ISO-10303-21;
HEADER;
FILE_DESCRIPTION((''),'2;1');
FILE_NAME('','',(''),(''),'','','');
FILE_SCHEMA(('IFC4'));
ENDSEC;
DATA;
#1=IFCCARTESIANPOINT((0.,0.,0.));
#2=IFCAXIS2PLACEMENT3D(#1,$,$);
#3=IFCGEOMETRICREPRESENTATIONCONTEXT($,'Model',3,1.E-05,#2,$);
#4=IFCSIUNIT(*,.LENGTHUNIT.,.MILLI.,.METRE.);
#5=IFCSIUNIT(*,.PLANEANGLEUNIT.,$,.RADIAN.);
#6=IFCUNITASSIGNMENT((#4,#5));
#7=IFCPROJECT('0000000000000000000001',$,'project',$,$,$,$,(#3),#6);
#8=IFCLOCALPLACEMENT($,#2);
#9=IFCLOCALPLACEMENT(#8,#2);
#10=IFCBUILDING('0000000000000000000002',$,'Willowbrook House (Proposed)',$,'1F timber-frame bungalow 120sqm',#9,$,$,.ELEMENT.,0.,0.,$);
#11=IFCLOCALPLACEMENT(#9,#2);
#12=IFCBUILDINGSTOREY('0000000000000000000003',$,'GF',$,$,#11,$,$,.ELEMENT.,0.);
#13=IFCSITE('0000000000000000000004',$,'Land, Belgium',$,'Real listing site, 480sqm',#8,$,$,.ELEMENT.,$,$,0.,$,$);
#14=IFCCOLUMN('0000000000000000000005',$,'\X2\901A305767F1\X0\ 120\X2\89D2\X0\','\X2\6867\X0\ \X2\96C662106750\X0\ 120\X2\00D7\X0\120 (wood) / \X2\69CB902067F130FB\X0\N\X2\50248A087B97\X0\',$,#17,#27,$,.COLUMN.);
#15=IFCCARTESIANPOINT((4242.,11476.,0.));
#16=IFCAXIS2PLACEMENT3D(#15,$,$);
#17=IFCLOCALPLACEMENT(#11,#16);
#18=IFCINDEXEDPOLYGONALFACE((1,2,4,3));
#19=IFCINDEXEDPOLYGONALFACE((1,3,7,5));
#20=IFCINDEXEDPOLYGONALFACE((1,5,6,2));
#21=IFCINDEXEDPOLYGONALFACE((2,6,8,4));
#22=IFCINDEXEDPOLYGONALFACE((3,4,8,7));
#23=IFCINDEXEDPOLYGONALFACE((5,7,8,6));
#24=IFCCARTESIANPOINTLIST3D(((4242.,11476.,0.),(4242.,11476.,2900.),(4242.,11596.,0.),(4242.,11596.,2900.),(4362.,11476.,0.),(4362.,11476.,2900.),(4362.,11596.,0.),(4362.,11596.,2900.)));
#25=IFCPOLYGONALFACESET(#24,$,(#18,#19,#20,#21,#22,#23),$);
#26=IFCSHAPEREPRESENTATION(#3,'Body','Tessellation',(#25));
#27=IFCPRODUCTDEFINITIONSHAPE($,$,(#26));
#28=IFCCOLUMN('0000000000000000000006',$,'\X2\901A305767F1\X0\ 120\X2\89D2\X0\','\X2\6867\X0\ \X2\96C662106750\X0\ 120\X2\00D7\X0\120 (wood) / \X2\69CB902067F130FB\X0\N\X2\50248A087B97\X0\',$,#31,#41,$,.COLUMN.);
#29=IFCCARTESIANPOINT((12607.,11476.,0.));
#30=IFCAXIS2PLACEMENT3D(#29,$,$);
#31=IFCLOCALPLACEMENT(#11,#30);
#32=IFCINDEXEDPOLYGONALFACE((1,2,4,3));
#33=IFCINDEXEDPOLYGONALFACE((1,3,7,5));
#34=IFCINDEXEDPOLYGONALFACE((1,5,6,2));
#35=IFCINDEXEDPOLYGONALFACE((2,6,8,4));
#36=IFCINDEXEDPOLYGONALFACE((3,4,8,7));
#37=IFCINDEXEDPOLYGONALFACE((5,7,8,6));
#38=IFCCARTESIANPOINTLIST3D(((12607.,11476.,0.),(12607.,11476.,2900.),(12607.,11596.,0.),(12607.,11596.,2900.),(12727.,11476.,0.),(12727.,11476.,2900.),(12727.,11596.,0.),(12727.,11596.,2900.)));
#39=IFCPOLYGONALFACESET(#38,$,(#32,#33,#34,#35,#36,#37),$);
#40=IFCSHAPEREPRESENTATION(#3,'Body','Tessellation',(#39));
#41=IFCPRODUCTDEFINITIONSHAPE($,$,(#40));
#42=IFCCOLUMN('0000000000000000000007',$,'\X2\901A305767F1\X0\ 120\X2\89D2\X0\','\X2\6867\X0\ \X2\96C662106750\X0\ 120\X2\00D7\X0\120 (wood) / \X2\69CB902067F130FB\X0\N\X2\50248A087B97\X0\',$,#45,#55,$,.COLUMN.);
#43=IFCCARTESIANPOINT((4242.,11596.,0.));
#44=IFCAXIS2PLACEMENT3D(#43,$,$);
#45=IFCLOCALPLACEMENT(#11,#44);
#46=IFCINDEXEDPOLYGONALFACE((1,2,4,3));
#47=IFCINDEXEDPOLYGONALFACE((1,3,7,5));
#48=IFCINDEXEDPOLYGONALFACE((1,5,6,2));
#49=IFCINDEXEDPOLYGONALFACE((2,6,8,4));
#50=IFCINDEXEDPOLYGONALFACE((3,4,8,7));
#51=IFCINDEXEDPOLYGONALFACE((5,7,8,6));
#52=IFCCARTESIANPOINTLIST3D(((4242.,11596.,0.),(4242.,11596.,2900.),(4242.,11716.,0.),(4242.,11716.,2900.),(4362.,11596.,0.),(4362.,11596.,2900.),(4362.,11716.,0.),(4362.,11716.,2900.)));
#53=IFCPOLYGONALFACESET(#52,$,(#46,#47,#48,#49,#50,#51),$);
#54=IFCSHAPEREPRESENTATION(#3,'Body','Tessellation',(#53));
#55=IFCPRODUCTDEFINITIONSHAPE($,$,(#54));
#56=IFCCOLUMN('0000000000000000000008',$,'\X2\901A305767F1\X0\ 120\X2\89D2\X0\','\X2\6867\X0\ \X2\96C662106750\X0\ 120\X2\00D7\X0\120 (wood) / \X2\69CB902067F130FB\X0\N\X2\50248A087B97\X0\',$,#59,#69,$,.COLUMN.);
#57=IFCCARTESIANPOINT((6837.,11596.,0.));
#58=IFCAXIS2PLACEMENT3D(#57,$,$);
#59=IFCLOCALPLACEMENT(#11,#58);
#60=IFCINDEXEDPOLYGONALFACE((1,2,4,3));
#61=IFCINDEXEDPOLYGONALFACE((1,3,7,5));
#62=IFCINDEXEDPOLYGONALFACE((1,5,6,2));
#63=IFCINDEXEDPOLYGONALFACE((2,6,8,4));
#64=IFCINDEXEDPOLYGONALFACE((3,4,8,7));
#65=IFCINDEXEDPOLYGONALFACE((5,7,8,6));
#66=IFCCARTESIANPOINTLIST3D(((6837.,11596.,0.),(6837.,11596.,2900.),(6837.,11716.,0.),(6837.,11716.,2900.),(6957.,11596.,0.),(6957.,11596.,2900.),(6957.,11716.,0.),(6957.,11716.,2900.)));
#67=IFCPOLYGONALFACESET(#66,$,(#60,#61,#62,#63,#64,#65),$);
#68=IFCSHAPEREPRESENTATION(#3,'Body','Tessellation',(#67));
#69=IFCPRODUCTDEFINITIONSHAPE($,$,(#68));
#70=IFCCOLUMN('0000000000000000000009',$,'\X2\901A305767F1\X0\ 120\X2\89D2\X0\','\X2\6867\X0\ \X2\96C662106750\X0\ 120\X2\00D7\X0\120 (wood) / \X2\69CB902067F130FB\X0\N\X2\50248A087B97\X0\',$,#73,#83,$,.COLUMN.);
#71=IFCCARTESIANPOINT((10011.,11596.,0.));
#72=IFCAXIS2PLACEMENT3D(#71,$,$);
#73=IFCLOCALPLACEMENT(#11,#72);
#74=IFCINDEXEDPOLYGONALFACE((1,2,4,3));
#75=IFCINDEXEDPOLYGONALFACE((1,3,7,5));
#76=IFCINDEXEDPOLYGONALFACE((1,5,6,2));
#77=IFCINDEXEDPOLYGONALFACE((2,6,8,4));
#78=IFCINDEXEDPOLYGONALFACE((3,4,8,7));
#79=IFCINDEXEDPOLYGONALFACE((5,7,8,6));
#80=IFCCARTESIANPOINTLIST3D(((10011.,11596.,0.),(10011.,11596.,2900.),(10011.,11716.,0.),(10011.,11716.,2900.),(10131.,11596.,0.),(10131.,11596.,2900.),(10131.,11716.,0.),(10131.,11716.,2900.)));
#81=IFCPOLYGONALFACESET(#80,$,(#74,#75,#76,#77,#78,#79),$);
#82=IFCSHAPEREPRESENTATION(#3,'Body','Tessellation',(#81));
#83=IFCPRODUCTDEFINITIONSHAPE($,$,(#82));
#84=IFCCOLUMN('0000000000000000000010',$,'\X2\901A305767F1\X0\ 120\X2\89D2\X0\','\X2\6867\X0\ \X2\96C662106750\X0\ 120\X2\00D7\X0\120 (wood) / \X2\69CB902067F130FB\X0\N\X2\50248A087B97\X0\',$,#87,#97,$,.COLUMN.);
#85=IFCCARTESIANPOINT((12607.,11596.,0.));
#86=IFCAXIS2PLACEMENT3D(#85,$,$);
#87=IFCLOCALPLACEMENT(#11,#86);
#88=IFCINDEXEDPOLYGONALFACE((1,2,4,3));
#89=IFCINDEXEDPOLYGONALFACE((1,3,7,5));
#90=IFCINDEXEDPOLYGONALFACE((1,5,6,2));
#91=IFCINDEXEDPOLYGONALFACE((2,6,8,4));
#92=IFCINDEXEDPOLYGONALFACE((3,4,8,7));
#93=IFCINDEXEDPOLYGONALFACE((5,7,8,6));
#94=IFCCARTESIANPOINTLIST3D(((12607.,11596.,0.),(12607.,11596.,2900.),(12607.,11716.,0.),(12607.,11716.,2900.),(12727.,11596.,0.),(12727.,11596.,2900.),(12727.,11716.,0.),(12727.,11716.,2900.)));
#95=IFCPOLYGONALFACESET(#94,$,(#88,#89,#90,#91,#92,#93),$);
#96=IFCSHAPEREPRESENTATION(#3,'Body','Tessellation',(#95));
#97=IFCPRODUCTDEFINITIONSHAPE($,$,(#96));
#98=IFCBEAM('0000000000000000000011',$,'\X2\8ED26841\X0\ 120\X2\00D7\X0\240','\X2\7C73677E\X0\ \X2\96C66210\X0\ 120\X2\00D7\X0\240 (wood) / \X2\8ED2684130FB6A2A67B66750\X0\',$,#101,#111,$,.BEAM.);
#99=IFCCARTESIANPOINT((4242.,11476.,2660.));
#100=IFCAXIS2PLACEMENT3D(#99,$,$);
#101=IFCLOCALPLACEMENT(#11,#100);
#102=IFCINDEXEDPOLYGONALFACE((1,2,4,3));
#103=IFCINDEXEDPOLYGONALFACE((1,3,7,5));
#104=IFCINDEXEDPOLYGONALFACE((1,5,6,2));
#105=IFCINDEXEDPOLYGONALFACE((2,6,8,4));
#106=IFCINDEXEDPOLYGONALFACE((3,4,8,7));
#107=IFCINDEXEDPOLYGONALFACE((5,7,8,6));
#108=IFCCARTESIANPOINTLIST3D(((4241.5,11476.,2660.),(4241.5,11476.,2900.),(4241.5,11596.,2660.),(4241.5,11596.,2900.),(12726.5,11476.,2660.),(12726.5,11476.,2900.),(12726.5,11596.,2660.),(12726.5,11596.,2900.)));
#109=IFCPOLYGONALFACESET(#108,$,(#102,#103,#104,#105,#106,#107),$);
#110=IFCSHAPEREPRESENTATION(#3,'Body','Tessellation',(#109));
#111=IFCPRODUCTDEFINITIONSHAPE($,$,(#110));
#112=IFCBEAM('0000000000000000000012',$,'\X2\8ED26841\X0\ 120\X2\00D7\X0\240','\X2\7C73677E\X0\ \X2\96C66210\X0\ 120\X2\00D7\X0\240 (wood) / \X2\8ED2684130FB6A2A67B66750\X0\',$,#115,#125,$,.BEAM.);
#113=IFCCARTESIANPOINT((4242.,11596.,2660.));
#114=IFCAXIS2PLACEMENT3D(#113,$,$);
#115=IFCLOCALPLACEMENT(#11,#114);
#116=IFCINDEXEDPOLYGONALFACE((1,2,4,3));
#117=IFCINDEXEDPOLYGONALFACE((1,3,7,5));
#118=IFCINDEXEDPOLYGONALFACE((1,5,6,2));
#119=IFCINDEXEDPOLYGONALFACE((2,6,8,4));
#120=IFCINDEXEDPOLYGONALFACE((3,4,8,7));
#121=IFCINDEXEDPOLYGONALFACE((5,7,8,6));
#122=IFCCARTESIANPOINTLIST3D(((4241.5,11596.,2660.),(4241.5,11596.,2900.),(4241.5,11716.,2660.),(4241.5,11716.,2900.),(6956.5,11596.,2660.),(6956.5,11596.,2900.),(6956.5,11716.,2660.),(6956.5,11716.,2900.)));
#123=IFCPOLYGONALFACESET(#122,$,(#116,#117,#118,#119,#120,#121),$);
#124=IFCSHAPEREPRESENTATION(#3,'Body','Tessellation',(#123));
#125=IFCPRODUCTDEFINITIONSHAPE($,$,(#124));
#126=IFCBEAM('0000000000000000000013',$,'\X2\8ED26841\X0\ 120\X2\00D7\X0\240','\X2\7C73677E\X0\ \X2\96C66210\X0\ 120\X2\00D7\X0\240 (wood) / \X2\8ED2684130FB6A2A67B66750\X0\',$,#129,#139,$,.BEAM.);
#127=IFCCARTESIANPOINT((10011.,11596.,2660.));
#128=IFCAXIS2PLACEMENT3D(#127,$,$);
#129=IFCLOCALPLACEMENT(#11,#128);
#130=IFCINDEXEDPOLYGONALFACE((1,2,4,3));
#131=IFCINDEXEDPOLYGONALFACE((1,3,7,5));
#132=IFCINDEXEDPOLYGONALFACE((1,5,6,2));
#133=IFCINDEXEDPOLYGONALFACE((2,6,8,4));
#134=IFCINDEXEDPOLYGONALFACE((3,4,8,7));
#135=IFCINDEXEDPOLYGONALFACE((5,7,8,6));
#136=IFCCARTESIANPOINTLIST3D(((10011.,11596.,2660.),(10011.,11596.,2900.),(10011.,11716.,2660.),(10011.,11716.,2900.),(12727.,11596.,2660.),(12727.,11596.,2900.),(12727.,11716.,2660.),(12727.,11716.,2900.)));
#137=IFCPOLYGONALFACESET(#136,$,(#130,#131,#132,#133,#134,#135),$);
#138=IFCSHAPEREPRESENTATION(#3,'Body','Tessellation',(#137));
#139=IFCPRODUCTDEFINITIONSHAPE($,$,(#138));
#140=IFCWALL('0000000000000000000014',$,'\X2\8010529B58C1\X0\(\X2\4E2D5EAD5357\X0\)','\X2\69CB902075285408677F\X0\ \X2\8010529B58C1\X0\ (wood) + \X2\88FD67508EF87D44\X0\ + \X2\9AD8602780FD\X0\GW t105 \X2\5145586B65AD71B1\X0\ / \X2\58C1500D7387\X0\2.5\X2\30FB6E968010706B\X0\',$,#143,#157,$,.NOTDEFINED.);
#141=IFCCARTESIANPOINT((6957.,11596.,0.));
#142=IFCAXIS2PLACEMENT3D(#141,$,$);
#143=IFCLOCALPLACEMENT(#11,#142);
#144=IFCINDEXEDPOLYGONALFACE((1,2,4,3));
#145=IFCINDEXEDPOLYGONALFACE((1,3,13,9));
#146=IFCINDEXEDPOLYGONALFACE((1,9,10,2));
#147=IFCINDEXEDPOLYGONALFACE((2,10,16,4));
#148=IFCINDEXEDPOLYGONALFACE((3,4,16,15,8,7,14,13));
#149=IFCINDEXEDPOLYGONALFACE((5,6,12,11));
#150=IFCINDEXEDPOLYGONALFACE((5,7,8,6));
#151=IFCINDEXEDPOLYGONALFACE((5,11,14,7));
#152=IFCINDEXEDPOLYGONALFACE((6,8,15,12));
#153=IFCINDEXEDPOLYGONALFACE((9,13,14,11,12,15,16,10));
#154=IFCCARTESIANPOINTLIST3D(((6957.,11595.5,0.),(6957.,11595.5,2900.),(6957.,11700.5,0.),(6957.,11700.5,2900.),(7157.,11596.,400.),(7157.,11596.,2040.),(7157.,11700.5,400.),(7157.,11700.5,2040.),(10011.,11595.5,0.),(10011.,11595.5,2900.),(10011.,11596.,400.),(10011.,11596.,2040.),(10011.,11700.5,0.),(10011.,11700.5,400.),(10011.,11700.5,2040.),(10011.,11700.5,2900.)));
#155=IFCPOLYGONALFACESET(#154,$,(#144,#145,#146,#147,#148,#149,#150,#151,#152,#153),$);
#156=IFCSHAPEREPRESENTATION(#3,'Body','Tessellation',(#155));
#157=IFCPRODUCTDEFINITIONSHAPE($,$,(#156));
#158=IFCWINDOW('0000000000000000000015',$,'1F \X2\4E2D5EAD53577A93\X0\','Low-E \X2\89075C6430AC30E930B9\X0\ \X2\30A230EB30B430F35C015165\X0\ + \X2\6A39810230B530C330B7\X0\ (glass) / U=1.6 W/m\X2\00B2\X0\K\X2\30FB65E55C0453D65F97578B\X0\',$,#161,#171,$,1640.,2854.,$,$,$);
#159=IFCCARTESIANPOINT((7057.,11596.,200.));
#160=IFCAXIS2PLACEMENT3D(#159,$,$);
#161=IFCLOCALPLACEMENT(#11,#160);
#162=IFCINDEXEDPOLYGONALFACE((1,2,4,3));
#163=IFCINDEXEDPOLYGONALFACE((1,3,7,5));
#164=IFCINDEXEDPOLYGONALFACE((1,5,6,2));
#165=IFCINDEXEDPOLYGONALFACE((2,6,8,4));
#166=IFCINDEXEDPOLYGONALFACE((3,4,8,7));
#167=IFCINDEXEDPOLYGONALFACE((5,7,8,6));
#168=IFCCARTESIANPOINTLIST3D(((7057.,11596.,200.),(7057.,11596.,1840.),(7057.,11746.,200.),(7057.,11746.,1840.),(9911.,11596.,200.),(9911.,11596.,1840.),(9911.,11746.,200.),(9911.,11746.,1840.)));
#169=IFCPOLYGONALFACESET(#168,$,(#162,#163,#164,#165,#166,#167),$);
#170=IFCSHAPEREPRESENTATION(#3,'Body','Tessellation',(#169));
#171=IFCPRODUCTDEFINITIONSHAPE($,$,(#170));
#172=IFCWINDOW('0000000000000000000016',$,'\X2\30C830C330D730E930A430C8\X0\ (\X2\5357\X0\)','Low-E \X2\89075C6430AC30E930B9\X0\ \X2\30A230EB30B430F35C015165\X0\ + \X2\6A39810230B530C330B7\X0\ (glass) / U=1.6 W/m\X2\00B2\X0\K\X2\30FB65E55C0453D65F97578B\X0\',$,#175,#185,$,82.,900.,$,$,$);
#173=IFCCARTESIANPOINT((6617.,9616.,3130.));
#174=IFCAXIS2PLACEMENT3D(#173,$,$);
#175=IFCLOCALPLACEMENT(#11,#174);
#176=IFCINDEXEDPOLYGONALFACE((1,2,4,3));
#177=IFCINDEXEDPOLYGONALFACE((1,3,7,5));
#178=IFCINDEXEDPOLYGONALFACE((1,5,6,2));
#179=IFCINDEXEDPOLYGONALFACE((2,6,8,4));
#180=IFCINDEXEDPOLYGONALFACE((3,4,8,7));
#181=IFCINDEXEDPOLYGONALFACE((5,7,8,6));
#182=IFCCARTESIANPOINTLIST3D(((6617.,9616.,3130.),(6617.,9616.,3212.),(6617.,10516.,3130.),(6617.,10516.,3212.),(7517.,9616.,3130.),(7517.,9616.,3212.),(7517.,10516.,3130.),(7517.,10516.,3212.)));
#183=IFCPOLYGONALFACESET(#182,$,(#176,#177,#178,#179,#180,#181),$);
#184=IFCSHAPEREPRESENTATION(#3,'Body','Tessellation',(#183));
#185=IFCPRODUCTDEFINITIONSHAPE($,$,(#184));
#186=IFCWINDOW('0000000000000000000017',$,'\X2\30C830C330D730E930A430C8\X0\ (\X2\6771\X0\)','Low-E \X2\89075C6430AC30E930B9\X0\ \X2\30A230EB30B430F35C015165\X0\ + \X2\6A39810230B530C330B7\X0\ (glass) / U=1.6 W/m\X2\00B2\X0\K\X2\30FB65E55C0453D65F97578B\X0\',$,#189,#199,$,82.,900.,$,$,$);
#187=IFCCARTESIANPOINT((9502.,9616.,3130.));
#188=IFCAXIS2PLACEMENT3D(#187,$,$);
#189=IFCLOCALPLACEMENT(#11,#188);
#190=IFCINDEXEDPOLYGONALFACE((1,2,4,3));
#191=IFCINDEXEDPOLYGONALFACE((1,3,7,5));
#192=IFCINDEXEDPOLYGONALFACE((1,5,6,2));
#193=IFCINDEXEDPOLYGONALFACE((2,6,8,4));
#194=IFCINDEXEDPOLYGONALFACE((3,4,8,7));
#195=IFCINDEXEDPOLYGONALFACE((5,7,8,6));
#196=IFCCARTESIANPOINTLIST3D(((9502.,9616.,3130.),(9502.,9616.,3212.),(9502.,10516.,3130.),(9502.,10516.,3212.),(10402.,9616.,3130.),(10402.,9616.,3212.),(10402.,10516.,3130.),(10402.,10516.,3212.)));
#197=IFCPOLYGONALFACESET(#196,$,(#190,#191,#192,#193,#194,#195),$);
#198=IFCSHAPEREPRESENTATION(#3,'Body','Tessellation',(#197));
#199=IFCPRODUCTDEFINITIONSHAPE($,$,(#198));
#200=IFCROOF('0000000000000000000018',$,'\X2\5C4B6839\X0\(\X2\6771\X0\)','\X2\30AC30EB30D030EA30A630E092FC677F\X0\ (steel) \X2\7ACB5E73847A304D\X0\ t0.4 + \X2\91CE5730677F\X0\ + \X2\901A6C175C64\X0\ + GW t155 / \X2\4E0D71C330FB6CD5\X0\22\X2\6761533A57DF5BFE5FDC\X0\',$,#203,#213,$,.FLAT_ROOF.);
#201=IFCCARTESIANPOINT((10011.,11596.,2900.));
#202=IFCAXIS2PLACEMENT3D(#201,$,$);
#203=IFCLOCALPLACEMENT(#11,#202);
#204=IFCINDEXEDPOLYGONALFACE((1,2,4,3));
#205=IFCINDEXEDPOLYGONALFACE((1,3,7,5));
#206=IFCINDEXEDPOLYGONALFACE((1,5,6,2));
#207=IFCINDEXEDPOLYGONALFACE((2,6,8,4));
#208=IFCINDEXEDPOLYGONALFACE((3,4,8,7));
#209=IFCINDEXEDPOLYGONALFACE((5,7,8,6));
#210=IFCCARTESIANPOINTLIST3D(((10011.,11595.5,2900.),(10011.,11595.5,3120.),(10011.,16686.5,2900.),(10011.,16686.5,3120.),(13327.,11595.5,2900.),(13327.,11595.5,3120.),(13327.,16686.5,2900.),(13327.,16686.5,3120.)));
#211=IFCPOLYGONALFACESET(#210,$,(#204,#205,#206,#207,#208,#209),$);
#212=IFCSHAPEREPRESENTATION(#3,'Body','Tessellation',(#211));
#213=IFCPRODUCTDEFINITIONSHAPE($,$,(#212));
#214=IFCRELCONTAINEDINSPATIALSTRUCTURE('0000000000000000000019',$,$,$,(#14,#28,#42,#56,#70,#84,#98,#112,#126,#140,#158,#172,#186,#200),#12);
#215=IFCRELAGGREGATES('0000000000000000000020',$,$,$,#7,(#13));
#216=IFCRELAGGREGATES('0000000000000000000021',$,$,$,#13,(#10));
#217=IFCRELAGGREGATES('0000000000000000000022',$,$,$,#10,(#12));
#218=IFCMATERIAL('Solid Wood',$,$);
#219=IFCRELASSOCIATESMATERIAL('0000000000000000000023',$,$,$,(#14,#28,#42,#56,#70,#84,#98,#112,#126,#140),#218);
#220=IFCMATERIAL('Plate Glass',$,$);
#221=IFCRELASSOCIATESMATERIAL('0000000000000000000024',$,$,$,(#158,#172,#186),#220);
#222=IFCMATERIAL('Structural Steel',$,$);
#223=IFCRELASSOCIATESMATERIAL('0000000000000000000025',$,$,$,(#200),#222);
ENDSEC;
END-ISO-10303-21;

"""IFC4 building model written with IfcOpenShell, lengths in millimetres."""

from ifc_helpers import new_model, si_unit, frame, frame_2d, origin, place, context, project, spatial, rectangle, extrude, material, element, fill, save


model = new_model("IFC4")

# Units and contexts
model_context = context("Model", 3, precision=1e-05, world=origin())
ifc_project = project(units=[si_unit("LENGTHUNIT", "METRE", prefix="MILLI"), si_unit("PLANEANGLEUNIT", "RADIAN")], contexts=[model_context])

# Site, building, storey
site_placement = place(None, origin())
site = spatial("IfcSite", under=ifc_project, at=site_placement, Name="Land, Belgium", ObjectType="Real listing site, 480sqm", CompositionType="ELEMENT", RefElevation=0.0)
building_placement = place(site_placement, origin())
building = spatial("IfcBuilding", under=site, at=building_placement, Name="Willowbrook House (Proposed)", ObjectType="1F timber-frame bungalow 120sqm", CompositionType="ELEMENT", ElevationOfRefHeight=0.0, ElevationOfTerrain=0.0)
storey_placement = place(building_placement, origin())
storey = spatial("IfcBuildingStorey", under=building, at=storey_placement, Name="GF", CompositionType="ELEMENT", Elevation=0.0)

# Columns
ifc_material_1 = material(Name="Solid Wood")
column_1_placement = place(storey_placement, frame((4242.0, 11476.0, 0.0)))
element("IfcColumn", 1, at=column_1_placement, inside=storey, material=ifc_material_1, Name="通し柱 120角", Description="桧 集成材 120×120 (wood) / 構造柱・N値計算", PredefinedType="COLUMN", context=model_context, shape_type="SweptSolid", body=[
    extrude(rectangle(XDim=120.0, YDim=120.0, at=frame_2d((60.0, 60.0))), frame((4242.0, 11476.0, 0.0)), (0.0, 0.0, 1.0), 2900.0),
])
column_2_placement = place(storey_placement, frame((12607.0, 11476.0, 0.0)))
element("IfcColumn", 2, at=column_2_placement, inside=storey, material=ifc_material_1, Name="通し柱 120角", Description="桧 集成材 120×120 (wood) / 構造柱・N値計算", PredefinedType="COLUMN", context=model_context, shape_type="SweptSolid", body=[
    extrude(rectangle(XDim=120.0, YDim=120.0, at=frame_2d((60.0, 60.0))), frame((12607.0, 11476.0, 0.0)), (0.0, 0.0, 1.0), 2900.0),
])
column_3_placement = place(storey_placement, frame((4242.0, 11596.0, 0.0)))
element("IfcColumn", 3, at=column_3_placement, inside=storey, material=ifc_material_1, Name="通し柱 120角", Description="桧 集成材 120×120 (wood) / 構造柱・N値計算", PredefinedType="COLUMN", context=model_context, shape_type="SweptSolid", body=[
    extrude(rectangle(XDim=120.0, YDim=120.0, at=frame_2d((60.0, 60.0))), frame((4242.0, 11596.0, 0.0)), (0.0, 0.0, 1.0), 2900.0),
])
column_4_placement = place(storey_placement, frame((6837.0, 11596.0, 0.0)))
element("IfcColumn", 4, at=column_4_placement, inside=storey, material=ifc_material_1, Name="通し柱 120角", Description="桧 集成材 120×120 (wood) / 構造柱・N値計算", PredefinedType="COLUMN", context=model_context, shape_type="SweptSolid", body=[
    extrude(rectangle(XDim=120.0, YDim=120.0, at=frame_2d((60.0, 60.0))), frame((6837.0, 11596.0, 0.0)), (0.0, 0.0, 1.0), 2900.0),
])
column_5_placement = place(storey_placement, frame((10011.0, 11596.0, 0.0)))
element("IfcColumn", 5, at=column_5_placement, inside=storey, material=ifc_material_1, Name="通し柱 120角", Description="桧 集成材 120×120 (wood) / 構造柱・N値計算", PredefinedType="COLUMN", context=model_context, shape_type="SweptSolid", body=[
    extrude(rectangle(XDim=120.0, YDim=120.0, at=frame_2d((60.0, 60.0))), frame((10011.0, 11596.0, 0.0)), (0.0, 0.0, 1.0), 2900.0),
])
column_6_placement = place(storey_placement, frame((12607.0, 11596.0, 0.0)))
element("IfcColumn", 6, at=column_6_placement, inside=storey, material=ifc_material_1, Name="通し柱 120角", Description="桧 集成材 120×120 (wood) / 構造柱・N値計算", PredefinedType="COLUMN", context=model_context, shape_type="SweptSolid", body=[
    extrude(rectangle(XDim=120.0, YDim=120.0, at=frame_2d((60.0, 60.0))), frame((12607.0, 11596.0, 0.0)), (0.0, 0.0, 1.0), 2900.0),
])

# Beams
beam_1_placement = place(storey_placement, frame((4242.0, 11476.0, 2660.0)))
element("IfcBeam", 7, at=beam_1_placement, inside=storey, material=ifc_material_1, Name="軒桁 120×240", Description="米松 集成 120×240 (wood) / 軒桁・横架材", PredefinedType="BEAM", context=model_context, shape_type="SweptSolid", body=[
    extrude(rectangle(XDim=8485.0, YDim=120.0, at=frame_2d((4242.0, 60.0))), frame((4242.0, 11476.0, 2660.0)), (0.0, 0.0, 1.0), 240.0),
])
beam_2_placement = place(storey_placement, frame((4242.0, 11596.0, 2660.0)))
element("IfcBeam", 8, at=beam_2_placement, inside=storey, material=ifc_material_1, Name="軒桁 120×240", Description="米松 集成 120×240 (wood) / 軒桁・横架材", PredefinedType="BEAM", context=model_context, shape_type="SweptSolid", body=[
    extrude(rectangle(XDim=2715.0, YDim=120.0, at=frame_2d((1357.0, 60.0))), frame((4242.0, 11596.0, 2660.0)), (0.0, 0.0, 1.0), 240.0),
])
beam_3_placement = place(storey_placement, frame((10011.0, 11596.0, 2660.0)))
element("IfcBeam", 9, at=beam_3_placement, inside=storey, material=ifc_material_1, Name="軒桁 120×240", Description="米松 集成 120×240 (wood) / 軒桁・横架材", PredefinedType="BEAM", context=model_context, shape_type="SweptSolid", body=[
    extrude(rectangle(XDim=2716.0, YDim=120.0, at=frame_2d((1358.0, 60.0))), frame((10011.0, 11596.0, 2660.0)), (0.0, 0.0, 1.0), 240.0),
])

# Wall, opening, window
wall_1_placement = place(storey_placement, frame((6957.0, 11596.0, 0.0)))
wall_1 = element("IfcWall", 10, at=wall_1_placement, inside=storey, material=ifc_material_1, Name="耐力壁(中庭南)", Description="構造用合板 耐力壁 (wood) + 製材軸組 + 高性能GW t105 充填断熱 / 壁倍率2.5・準耐火", PredefinedType="NOTDEFINED", context=model_context, shape_type="SweptSolid", body=[
    extrude(rectangle(XDim=3054.0, YDim=105.0, at=frame_2d((1527.0, 52.0))), frame((6957.0, 11596.0, 0.0)), (0.0, 0.0, 1.0), 2900.0),
])
opening_placement = place(storey_placement, frame((7057.0, 11596.0, 200.0)))
opening = element("IfcOpeningElement", 11, at=opening_placement, cuts=wall_1, PredefinedType="NOTDEFINED", context=model_context, shape_type="SweptSolid", body=[
    extrude(rectangle(XDim=2854.0, YDim=150.0, at=frame_2d((1427.0, 75.0))), frame((7057.0, 11596.0, 200.0)), (0.0, 0.0, 1.0), 1640.0),
])
ifc_material_2 = material(Name="Plate Glass")
window_1_placement = place(storey_placement, frame((7057.0, 11596.0, 200.0)))
window_1 = element("IfcWindow", 12, at=window_1_placement, inside=storey, material=ifc_material_2, Name="1F 中庭南窓", Description="Low-E 複層ガラス アルゴン封入 + 樹脂サッシ (glass) / U=1.6 W/m²K・日射取得型", OverallHeight=1640.0, OverallWidth=2854.0, context=model_context, shape_type="SweptSolid", body=[
    extrude(rectangle(XDim=2854.0, YDim=150.0, at=frame_2d((1427.0, 75.0))), frame((7057.0, 11596.0, 200.0)), (0.0, 0.0, 1.0), 1640.0),
])
fill(opening, window_1)

# Windows
window_2_placement = place(storey_placement, frame((6617.0, 9616.0, 3130.0)))
element("IfcWindow", 13, at=window_2_placement, inside=storey, material=ifc_material_2, Name="トップライト (南)", Description="Low-E 複層ガラス アルゴン封入 + 樹脂サッシ (glass) / U=1.6 W/m²K・日射取得型", OverallHeight=82.0, OverallWidth=900.0, context=model_context, shape_type="SweptSolid", body=[
    extrude(rectangle(XDim=900.0, YDim=900.0, at=frame_2d((450.0, 450.0))), frame((6617.0, 9616.0, 3130.0)), (0.0, 0.0, 1.0), 82.0),
])
window_3_placement = place(storey_placement, frame((9502.0, 9616.0, 3130.0)))
element("IfcWindow", 14, at=window_3_placement, inside=storey, material=ifc_material_2, Name="トップライト (東)", Description="Low-E 複層ガラス アルゴン封入 + 樹脂サッシ (glass) / U=1.6 W/m²K・日射取得型", OverallHeight=82.0, OverallWidth=900.0, context=model_context, shape_type="SweptSolid", body=[
    extrude(rectangle(XDim=900.0, YDim=900.0, at=frame_2d((450.0, 450.0))), frame((9502.0, 9616.0, 3130.0)), (0.0, 0.0, 1.0), 82.0),
])

# Roof
ifc_material_3 = material(Name="Structural Steel")
roof_1_placement = place(storey_placement, frame((10011.0, 11596.0, 2900.0)))
element("IfcRoof", 15, at=roof_1_placement, inside=storey, material=ifc_material_3, Name="屋根(東)", Description="ガルバリウム鋼板 (steel) 立平葺き t0.4 + 野地板 + 通気層 + GW t155 / 不燃・法22条区域対応", PredefinedType="FLAT_ROOF", context=model_context, shape_type="SweptSolid", body=[
    extrude(rectangle(XDim=3316.0, YDim=5091.0, at=frame_2d((1658.0, 2545.0))), frame((10011.0, 11596.0, 2900.0)), (0.0, 0.0, 1.0), 220.0),
])

save(model, "model.ifc")
